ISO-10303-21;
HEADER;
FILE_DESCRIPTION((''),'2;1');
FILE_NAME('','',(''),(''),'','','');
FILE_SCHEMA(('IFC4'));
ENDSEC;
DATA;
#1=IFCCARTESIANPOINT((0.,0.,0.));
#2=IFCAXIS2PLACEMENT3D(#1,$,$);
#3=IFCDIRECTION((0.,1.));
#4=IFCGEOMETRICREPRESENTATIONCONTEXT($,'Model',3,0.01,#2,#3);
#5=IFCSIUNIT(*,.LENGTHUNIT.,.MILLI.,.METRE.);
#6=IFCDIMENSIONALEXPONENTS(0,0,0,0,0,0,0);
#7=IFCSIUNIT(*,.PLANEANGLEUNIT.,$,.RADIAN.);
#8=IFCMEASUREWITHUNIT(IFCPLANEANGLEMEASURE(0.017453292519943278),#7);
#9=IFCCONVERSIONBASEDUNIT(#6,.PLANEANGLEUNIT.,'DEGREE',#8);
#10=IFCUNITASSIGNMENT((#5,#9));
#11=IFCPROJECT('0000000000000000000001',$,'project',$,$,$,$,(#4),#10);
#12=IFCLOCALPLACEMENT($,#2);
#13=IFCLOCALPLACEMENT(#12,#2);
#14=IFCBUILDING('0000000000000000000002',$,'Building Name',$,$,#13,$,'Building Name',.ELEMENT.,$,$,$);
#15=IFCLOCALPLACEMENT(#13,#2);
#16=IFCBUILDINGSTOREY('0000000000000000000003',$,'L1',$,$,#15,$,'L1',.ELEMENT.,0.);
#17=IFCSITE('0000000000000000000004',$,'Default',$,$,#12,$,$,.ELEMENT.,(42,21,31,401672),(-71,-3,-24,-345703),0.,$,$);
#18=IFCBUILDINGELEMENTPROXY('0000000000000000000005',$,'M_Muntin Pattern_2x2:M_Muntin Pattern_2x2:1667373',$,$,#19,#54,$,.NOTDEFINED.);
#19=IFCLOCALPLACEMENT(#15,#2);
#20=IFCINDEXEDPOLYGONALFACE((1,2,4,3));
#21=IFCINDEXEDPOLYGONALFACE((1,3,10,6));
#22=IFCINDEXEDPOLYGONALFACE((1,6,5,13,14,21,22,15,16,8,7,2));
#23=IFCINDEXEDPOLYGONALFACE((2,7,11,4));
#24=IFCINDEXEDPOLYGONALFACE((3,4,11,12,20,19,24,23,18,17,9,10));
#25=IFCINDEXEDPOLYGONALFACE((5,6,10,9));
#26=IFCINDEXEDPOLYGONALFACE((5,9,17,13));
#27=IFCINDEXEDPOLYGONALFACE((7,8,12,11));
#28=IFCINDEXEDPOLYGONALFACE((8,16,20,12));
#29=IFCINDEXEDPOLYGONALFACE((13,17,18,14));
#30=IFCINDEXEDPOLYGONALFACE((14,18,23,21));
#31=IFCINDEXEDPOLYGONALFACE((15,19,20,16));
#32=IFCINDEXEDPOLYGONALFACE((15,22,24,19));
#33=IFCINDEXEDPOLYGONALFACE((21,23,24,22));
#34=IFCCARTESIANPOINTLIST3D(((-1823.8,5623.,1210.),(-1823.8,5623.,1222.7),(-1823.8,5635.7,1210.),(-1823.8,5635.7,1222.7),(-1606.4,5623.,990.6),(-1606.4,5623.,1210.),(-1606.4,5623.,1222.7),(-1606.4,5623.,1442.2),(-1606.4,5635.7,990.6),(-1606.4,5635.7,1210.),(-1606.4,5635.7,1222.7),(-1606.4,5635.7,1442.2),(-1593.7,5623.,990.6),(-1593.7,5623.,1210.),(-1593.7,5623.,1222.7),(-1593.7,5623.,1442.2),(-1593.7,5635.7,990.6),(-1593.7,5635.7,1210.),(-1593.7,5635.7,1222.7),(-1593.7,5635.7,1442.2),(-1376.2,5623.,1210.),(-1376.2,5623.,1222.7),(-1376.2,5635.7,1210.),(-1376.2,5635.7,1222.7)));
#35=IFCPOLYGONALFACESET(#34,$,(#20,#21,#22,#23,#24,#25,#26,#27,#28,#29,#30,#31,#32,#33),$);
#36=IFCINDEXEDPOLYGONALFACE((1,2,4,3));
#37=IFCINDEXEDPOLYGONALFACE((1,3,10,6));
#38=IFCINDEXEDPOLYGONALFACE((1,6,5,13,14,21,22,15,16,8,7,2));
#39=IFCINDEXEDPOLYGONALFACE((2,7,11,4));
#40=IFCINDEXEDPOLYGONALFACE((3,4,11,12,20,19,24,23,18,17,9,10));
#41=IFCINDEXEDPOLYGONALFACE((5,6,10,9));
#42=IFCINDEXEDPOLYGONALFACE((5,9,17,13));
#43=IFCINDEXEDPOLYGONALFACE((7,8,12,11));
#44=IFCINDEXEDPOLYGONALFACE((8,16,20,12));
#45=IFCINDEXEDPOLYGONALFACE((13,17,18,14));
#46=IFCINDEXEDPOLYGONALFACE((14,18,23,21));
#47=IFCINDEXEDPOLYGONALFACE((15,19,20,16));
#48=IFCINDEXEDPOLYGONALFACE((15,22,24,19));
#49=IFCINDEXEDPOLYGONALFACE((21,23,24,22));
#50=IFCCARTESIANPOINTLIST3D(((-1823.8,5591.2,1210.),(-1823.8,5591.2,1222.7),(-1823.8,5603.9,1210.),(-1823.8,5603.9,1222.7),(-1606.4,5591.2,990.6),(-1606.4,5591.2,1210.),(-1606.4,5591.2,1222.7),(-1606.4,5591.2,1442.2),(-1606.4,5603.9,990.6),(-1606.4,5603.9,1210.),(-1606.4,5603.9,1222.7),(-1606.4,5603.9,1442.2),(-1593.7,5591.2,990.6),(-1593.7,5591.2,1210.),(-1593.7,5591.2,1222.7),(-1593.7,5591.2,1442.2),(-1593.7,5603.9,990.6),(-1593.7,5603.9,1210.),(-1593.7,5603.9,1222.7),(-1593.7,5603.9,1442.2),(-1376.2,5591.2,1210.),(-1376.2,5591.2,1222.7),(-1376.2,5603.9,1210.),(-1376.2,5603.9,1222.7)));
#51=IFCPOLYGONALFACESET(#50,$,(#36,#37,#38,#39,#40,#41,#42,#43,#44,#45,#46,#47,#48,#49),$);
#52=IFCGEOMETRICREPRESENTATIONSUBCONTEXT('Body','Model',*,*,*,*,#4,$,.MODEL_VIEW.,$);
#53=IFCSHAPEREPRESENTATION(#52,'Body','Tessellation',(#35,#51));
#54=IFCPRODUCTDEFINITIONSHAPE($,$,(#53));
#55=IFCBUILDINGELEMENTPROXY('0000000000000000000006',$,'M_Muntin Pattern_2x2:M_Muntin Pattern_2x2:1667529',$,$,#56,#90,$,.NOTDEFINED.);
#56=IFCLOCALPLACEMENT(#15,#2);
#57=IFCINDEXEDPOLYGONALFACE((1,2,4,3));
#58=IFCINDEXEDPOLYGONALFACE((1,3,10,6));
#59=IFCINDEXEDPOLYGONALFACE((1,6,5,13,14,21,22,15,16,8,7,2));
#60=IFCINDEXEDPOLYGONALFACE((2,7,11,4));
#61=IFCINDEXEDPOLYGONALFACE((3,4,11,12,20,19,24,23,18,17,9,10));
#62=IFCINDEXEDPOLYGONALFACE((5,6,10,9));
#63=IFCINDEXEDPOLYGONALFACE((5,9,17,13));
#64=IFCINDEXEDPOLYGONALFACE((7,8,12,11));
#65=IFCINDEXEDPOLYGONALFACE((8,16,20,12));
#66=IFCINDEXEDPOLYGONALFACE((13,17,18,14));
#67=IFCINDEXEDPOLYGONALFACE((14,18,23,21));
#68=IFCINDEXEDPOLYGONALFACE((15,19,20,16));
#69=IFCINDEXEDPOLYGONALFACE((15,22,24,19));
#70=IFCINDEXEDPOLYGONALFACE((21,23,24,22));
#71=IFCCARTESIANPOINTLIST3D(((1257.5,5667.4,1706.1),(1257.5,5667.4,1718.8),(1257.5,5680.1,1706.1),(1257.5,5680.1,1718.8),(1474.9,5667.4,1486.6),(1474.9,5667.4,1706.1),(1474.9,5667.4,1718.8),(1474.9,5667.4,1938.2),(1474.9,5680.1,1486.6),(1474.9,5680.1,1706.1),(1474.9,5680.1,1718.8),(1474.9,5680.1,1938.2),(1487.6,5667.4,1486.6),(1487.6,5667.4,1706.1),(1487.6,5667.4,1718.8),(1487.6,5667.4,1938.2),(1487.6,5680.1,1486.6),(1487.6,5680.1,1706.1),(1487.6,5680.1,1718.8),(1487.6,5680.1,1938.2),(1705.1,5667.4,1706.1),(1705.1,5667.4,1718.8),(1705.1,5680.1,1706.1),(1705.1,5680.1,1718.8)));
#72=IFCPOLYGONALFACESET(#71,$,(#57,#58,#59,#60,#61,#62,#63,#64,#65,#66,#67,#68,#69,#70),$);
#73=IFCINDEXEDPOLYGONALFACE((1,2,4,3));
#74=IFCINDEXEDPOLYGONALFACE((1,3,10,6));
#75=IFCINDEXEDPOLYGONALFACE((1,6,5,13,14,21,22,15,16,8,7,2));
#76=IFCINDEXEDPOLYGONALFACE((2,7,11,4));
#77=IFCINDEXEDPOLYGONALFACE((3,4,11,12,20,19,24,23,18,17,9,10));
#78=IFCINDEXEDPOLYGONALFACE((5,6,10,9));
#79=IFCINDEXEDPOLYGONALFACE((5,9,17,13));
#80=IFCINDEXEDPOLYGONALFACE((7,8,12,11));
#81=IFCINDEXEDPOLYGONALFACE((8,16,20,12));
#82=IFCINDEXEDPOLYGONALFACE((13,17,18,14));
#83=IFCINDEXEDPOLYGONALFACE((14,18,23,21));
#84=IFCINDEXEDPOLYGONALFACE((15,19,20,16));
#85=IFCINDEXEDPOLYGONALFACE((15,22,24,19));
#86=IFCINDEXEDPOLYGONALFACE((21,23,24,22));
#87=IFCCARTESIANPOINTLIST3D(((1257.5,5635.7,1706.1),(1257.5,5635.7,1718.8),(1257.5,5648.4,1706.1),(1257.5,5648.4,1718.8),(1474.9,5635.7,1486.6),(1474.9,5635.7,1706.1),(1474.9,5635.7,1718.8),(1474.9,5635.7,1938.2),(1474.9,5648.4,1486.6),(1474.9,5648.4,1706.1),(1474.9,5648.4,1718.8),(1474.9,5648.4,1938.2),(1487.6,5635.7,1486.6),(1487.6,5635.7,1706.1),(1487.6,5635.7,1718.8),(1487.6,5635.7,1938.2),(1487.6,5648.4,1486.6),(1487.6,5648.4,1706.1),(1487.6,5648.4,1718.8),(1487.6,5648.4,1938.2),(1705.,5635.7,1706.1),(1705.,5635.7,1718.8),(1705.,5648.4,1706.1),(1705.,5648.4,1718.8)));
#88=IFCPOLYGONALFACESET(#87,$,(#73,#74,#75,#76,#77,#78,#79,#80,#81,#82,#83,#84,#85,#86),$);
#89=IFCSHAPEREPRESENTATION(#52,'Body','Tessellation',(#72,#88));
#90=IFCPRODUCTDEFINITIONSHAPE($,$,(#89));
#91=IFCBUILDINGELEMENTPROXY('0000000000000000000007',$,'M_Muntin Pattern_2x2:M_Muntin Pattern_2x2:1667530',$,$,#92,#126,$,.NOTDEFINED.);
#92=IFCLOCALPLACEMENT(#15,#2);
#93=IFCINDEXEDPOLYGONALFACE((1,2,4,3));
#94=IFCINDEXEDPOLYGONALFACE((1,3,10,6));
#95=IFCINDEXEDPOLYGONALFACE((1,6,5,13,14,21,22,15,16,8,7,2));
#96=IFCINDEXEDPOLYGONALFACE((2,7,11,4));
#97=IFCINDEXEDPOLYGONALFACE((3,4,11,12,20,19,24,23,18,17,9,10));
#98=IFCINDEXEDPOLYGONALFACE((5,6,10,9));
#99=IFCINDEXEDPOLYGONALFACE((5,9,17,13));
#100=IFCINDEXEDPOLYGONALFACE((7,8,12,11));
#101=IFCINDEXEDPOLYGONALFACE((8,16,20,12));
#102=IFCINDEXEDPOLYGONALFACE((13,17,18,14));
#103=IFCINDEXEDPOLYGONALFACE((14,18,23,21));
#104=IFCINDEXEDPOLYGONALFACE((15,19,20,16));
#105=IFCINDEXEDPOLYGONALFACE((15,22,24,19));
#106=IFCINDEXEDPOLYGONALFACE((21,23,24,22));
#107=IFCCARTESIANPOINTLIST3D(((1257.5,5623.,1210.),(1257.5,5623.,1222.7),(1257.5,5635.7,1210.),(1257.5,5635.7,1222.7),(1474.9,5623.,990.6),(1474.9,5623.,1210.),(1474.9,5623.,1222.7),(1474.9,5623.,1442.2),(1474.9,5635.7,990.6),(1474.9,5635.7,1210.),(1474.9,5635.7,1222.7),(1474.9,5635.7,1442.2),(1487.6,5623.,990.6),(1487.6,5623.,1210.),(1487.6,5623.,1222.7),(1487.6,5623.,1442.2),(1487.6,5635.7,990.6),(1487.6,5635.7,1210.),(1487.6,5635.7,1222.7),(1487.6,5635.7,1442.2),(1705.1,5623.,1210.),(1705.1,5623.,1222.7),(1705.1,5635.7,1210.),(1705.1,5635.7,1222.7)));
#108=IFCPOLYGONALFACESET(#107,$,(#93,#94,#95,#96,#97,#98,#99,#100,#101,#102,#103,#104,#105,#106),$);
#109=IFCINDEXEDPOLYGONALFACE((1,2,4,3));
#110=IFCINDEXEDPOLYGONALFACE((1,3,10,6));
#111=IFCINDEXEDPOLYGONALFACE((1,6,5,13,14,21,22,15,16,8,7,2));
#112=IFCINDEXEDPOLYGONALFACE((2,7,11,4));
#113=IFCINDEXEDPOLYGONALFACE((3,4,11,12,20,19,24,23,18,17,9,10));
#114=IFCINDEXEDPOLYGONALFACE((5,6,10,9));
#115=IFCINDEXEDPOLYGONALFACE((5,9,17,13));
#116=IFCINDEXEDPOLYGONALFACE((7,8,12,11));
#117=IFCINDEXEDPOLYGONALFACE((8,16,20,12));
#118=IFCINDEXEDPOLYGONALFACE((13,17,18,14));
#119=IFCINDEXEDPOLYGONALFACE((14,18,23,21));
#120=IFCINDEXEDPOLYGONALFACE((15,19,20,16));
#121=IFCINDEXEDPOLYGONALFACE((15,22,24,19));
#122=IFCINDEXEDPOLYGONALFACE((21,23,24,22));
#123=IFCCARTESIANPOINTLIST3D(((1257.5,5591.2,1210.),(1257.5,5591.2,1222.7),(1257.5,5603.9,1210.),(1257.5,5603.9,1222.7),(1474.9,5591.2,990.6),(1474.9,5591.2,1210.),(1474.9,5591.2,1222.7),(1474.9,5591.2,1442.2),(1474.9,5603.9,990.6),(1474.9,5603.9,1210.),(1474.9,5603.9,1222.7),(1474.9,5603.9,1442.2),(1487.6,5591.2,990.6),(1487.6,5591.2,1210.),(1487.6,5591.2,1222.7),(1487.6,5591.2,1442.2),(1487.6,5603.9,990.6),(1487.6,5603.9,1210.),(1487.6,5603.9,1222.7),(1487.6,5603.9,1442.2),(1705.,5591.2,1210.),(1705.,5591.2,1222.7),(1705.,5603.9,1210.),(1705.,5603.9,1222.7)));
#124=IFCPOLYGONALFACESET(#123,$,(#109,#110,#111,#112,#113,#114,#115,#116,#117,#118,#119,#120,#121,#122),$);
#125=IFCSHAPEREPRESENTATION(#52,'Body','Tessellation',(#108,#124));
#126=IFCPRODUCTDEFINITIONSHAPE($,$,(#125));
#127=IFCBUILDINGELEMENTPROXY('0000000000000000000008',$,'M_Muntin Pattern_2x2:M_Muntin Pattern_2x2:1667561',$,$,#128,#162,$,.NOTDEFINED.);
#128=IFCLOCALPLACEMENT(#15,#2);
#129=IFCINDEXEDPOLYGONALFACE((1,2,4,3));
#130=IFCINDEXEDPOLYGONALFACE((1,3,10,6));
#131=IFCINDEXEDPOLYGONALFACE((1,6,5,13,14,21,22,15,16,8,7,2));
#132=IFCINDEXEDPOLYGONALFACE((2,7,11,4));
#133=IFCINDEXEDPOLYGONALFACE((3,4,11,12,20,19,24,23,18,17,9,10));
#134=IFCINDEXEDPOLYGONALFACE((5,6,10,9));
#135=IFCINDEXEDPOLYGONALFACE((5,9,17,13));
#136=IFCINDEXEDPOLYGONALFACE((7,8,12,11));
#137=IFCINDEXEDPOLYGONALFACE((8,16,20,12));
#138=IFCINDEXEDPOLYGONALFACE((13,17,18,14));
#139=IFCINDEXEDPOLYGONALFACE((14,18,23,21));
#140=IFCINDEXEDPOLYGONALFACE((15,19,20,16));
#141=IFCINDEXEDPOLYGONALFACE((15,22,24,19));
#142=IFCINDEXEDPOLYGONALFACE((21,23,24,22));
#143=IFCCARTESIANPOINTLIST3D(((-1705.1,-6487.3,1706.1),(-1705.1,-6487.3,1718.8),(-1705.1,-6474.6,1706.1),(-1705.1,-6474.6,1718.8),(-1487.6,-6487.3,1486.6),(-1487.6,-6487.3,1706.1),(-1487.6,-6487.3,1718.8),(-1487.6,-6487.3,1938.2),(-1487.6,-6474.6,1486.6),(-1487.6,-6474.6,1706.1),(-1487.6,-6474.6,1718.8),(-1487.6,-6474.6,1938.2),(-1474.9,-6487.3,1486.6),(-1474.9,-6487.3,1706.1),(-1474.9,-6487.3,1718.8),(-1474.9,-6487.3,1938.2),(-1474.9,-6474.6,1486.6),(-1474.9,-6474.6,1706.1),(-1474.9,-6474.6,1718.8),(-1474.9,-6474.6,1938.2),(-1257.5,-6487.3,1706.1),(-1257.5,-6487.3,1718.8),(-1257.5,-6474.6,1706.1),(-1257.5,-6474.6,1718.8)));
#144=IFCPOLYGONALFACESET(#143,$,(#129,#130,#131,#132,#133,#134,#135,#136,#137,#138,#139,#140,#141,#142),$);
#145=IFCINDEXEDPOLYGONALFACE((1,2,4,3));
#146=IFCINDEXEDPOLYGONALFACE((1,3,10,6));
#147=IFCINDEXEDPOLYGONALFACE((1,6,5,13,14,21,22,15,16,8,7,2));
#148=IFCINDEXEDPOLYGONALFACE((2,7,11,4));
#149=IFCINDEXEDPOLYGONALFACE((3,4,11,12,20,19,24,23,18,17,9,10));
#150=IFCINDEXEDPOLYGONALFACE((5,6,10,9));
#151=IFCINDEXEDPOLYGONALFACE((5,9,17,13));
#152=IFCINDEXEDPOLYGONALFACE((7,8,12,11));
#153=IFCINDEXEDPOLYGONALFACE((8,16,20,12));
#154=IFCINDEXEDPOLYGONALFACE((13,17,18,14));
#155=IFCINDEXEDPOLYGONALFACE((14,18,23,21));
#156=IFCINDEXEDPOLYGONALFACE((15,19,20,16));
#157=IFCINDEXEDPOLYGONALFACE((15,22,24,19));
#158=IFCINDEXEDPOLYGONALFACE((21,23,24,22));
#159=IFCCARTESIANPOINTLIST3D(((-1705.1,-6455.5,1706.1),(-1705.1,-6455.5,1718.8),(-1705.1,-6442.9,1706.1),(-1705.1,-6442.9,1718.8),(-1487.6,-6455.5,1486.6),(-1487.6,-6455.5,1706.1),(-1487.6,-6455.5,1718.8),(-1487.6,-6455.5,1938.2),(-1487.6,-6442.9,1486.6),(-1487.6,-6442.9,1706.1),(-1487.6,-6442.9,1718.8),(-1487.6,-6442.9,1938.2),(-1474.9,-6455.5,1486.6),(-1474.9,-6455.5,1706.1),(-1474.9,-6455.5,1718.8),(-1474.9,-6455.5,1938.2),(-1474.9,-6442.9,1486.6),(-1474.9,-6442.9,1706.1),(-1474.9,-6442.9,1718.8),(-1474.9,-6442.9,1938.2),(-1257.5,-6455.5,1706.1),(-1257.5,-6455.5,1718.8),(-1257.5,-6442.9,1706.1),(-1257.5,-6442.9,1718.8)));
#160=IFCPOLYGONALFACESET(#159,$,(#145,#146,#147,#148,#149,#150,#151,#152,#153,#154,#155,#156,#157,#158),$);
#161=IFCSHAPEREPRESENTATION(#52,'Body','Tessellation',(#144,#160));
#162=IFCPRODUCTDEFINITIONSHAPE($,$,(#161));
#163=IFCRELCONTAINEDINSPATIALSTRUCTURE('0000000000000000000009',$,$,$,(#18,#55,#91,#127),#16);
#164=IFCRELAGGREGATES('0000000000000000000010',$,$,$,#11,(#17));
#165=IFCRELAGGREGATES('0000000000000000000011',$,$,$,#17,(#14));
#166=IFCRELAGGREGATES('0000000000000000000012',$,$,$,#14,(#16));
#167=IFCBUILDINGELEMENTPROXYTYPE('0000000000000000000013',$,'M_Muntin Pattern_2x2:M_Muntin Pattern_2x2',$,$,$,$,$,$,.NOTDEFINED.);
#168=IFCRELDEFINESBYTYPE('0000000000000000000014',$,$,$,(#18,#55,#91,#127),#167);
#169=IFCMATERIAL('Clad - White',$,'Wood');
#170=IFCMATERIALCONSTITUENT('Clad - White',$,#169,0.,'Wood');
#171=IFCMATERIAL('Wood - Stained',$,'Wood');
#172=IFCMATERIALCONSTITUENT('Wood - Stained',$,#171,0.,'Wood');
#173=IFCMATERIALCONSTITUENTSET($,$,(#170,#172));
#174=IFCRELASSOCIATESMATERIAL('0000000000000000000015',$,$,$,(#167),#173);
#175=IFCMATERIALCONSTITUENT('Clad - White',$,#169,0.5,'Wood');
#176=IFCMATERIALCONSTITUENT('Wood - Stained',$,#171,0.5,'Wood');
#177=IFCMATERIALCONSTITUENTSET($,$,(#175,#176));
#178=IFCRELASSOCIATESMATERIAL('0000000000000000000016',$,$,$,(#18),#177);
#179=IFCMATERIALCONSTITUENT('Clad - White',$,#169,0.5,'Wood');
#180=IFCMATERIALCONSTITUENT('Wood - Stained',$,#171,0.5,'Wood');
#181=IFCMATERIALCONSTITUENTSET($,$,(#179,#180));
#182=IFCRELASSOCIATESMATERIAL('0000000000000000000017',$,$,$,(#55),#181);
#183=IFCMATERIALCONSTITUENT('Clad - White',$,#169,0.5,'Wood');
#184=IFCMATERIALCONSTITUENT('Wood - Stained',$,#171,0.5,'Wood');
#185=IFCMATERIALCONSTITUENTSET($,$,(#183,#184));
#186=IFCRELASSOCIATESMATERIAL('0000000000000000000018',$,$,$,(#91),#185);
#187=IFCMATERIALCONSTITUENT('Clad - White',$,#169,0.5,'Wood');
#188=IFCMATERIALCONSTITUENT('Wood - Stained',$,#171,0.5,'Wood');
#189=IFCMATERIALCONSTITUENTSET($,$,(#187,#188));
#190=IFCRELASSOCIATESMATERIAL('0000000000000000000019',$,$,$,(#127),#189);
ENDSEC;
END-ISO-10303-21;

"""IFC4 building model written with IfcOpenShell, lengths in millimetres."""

from ifc_helpers import new_model, entity, si_unit, converted_unit, direction, frame, origin, place, context, subcontext, project, spatial, indexed_curve, outline, extrude, source, transform, mapped, material, constituent, constituent_set, type_object, type_shapes, element, save


model = new_model("IFC4")

# Units and contexts
model_context = context("Model", 3, precision=0.01, world=origin(), true_north=direction((0.0, 1.0)))
body_context = subcontext(model_context, "Body", "Model", "MODEL_VIEW")
ifc_project = project(units=[si_unit("LENGTHUNIT", "METRE", prefix="MILLI"), converted_unit("PLANEANGLEUNIT", "DEGREE", entity("IfcPlaneAngleMeasure", 0.017453292519943278), si_unit("PLANEANGLEUNIT", "RADIAN"), dimensions=[0, 0, 0, 0, 0, 0, 0])], contexts=[model_context])

# Site, building, storey
site_placement = place(None, origin())
site = spatial("IfcSite", under=ifc_project, at=site_placement, Name="Default", CompositionType="ELEMENT", RefLatitude=(42, 21, 31, 401672), RefLongitude=(-71, -3, -24, -345703), RefElevation=0.0)
building_placement = place(site_placement, origin())
building = spatial("IfcBuilding", under=site, at=building_placement, Name="Building Name", LongName="Building Name", CompositionType="ELEMENT")
storey_placement = place(building_placement, origin())
storey = spatial("IfcBuildingStorey", under=building, at=storey_placement, Name="L1", LongName="L1", CompositionType="ELEMENT", Elevation=0.0)

# Building element proxies
ifc_material_1 = material(Name="Clad - White", Category="Wood")
ifc_material_2 = material(Name="Wood - Stained", Category="Wood")
ifc_constituent_1 = constituent(ifc_material_1, Name="Clad - White", Category="Wood", fraction=0.0)
ifc_constituent_2 = constituent(ifc_material_2, Name="Wood - Stained", Category="Wood", fraction=0.0)
ifc_constituent_set_1 = constituent_set(constituents=[ifc_constituent_1, ifc_constituent_2])
building_element_proxy_type_1 = type_object("IfcBuildingElementProxyType", Name="M_Muntin Pattern_2x2:M_Muntin Pattern_2x2", PredefinedType="NOTDEFINED", material=ifc_constituent_set_1)
shared_shape_1 = source(origin(), body_context, "Body", "SweptSolid", [
    extrude(outline(indexed_curve([(6.4, -6.4), (225.8, -6.4), (225.8, 6.3), (6.4, 6.3), (6.4, 223.8), (-6.3, 223.8), (-6.3, 6.3), (-225.8, 6.3), (-225.8, -6.4), (-6.3, -6.4), (-6.3, -223.8), (6.4, -223.8), (6.4, -6.4)], self_intersect=False)), frame((0.0, 9.5, 225.8), z_axis=(0.0, 1.0, 0.0), x_axis=(0.0, 0.0, 1.0)), (0.0, 0.0, 1.0), 12.7),
    extrude(outline(indexed_curve([(6.4, -6.4), (225.8, -6.4), (225.8, 6.3), (6.4, 6.3), (6.4, 223.8), (-6.3, 223.8), (-6.3, 6.3), (-225.8, 6.3), (-225.8, -6.4), (-6.3, -6.4), (-6.3, -223.8), (6.4, -223.8), (6.4, -6.4)], self_intersect=False)), frame((0.0, -22.2, 225.8), z_axis=(0.0, 1.0, 0.0), x_axis=(0.0, 0.0, 1.0)), (0.0, 0.0, 1.0), 12.7),
])
type_shapes(building_element_proxy_type_1, [shared_shape_1])
ifc_constituent_3 = constituent(ifc_material_1, Name="Clad - White", Category="Wood", fraction=0.5)
ifc_constituent_4 = constituent(ifc_material_2, Name="Wood - Stained", Category="Wood", fraction=0.5)
ifc_constituent_set_2 = constituent_set(constituents=[ifc_constituent_3, ifc_constituent_4])
proxy_1_placement = place(storey_placement, frame((-1600.0, 5613.5, 990.6)))
element("IfcBuildingElementProxy", 1, at=proxy_1_placement, inside=storey, type_object=building_element_proxy_type_1, material=ifc_constituent_set_2, Name="M_Muntin Pattern_2x2:M_Muntin Pattern_2x2:1667373", PredefinedType="NOTDEFINED", context=body_context, shape_type="MappedRepresentation", body=[
    mapped(shared_shape_1, transform((0.0, 0.0, 0.0), scale=1.0)),
])
ifc_constituent_5 = constituent(ifc_material_1, Name="Clad - White", Category="Wood", fraction=0.5)
ifc_constituent_6 = constituent(ifc_material_2, Name="Wood - Stained", Category="Wood", fraction=0.5)
ifc_constituent_set_3 = constituent_set(constituents=[ifc_constituent_5, ifc_constituent_6])
proxy_2_placement = place(storey_placement, frame((1481.2, 5657.9, 1486.6)))
element("IfcBuildingElementProxy", 2, at=proxy_2_placement, inside=storey, type_object=building_element_proxy_type_1, material=ifc_constituent_set_3, Name="M_Muntin Pattern_2x2:M_Muntin Pattern_2x2:1667529", PredefinedType="NOTDEFINED", context=body_context, shape_type="MappedRepresentation", body=[
    mapped(shared_shape_1, transform((0.0, 0.0, 0.0), scale=1.0)),
])
ifc_constituent_7 = constituent(ifc_material_1, Name="Clad - White", Category="Wood", fraction=0.5)
ifc_constituent_8 = constituent(ifc_material_2, Name="Wood - Stained", Category="Wood", fraction=0.5)
ifc_constituent_set_4 = constituent_set(constituents=[ifc_constituent_7, ifc_constituent_8])
proxy_3_placement = place(storey_placement, frame((1481.2, 5613.5, 990.6)))
element("IfcBuildingElementProxy", 3, at=proxy_3_placement, inside=storey, type_object=building_element_proxy_type_1, material=ifc_constituent_set_4, Name="M_Muntin Pattern_2x2:M_Muntin Pattern_2x2:1667530", PredefinedType="NOTDEFINED", context=body_context, shape_type="MappedRepresentation", body=[
    mapped(shared_shape_1, transform((0.0, 0.0, 0.0), scale=1.0)),
])
ifc_constituent_9 = constituent(ifc_material_1, Name="Clad - White", Category="Wood", fraction=0.5)
ifc_constituent_10 = constituent(ifc_material_2, Name="Wood - Stained", Category="Wood", fraction=0.5)
ifc_constituent_set_5 = constituent_set(constituents=[ifc_constituent_9, ifc_constituent_10])
proxy_4_placement = place(storey_placement, frame((-1481.2, -6465.1, 1486.6), z_axis=(0.0, 0.0, 1.0), x_axis=(-1.0, 0.0, 0.0)))
element("IfcBuildingElementProxy", 4, at=proxy_4_placement, inside=storey, type_object=building_element_proxy_type_1, material=ifc_constituent_set_5, Name="M_Muntin Pattern_2x2:M_Muntin Pattern_2x2:1667561", PredefinedType="NOTDEFINED", context=body_context, shape_type="MappedRepresentation", body=[
    mapped(shared_shape_1, transform((0.0, 0.0, 0.0), scale=1.0)),
])

save(model, "model.ifc")
